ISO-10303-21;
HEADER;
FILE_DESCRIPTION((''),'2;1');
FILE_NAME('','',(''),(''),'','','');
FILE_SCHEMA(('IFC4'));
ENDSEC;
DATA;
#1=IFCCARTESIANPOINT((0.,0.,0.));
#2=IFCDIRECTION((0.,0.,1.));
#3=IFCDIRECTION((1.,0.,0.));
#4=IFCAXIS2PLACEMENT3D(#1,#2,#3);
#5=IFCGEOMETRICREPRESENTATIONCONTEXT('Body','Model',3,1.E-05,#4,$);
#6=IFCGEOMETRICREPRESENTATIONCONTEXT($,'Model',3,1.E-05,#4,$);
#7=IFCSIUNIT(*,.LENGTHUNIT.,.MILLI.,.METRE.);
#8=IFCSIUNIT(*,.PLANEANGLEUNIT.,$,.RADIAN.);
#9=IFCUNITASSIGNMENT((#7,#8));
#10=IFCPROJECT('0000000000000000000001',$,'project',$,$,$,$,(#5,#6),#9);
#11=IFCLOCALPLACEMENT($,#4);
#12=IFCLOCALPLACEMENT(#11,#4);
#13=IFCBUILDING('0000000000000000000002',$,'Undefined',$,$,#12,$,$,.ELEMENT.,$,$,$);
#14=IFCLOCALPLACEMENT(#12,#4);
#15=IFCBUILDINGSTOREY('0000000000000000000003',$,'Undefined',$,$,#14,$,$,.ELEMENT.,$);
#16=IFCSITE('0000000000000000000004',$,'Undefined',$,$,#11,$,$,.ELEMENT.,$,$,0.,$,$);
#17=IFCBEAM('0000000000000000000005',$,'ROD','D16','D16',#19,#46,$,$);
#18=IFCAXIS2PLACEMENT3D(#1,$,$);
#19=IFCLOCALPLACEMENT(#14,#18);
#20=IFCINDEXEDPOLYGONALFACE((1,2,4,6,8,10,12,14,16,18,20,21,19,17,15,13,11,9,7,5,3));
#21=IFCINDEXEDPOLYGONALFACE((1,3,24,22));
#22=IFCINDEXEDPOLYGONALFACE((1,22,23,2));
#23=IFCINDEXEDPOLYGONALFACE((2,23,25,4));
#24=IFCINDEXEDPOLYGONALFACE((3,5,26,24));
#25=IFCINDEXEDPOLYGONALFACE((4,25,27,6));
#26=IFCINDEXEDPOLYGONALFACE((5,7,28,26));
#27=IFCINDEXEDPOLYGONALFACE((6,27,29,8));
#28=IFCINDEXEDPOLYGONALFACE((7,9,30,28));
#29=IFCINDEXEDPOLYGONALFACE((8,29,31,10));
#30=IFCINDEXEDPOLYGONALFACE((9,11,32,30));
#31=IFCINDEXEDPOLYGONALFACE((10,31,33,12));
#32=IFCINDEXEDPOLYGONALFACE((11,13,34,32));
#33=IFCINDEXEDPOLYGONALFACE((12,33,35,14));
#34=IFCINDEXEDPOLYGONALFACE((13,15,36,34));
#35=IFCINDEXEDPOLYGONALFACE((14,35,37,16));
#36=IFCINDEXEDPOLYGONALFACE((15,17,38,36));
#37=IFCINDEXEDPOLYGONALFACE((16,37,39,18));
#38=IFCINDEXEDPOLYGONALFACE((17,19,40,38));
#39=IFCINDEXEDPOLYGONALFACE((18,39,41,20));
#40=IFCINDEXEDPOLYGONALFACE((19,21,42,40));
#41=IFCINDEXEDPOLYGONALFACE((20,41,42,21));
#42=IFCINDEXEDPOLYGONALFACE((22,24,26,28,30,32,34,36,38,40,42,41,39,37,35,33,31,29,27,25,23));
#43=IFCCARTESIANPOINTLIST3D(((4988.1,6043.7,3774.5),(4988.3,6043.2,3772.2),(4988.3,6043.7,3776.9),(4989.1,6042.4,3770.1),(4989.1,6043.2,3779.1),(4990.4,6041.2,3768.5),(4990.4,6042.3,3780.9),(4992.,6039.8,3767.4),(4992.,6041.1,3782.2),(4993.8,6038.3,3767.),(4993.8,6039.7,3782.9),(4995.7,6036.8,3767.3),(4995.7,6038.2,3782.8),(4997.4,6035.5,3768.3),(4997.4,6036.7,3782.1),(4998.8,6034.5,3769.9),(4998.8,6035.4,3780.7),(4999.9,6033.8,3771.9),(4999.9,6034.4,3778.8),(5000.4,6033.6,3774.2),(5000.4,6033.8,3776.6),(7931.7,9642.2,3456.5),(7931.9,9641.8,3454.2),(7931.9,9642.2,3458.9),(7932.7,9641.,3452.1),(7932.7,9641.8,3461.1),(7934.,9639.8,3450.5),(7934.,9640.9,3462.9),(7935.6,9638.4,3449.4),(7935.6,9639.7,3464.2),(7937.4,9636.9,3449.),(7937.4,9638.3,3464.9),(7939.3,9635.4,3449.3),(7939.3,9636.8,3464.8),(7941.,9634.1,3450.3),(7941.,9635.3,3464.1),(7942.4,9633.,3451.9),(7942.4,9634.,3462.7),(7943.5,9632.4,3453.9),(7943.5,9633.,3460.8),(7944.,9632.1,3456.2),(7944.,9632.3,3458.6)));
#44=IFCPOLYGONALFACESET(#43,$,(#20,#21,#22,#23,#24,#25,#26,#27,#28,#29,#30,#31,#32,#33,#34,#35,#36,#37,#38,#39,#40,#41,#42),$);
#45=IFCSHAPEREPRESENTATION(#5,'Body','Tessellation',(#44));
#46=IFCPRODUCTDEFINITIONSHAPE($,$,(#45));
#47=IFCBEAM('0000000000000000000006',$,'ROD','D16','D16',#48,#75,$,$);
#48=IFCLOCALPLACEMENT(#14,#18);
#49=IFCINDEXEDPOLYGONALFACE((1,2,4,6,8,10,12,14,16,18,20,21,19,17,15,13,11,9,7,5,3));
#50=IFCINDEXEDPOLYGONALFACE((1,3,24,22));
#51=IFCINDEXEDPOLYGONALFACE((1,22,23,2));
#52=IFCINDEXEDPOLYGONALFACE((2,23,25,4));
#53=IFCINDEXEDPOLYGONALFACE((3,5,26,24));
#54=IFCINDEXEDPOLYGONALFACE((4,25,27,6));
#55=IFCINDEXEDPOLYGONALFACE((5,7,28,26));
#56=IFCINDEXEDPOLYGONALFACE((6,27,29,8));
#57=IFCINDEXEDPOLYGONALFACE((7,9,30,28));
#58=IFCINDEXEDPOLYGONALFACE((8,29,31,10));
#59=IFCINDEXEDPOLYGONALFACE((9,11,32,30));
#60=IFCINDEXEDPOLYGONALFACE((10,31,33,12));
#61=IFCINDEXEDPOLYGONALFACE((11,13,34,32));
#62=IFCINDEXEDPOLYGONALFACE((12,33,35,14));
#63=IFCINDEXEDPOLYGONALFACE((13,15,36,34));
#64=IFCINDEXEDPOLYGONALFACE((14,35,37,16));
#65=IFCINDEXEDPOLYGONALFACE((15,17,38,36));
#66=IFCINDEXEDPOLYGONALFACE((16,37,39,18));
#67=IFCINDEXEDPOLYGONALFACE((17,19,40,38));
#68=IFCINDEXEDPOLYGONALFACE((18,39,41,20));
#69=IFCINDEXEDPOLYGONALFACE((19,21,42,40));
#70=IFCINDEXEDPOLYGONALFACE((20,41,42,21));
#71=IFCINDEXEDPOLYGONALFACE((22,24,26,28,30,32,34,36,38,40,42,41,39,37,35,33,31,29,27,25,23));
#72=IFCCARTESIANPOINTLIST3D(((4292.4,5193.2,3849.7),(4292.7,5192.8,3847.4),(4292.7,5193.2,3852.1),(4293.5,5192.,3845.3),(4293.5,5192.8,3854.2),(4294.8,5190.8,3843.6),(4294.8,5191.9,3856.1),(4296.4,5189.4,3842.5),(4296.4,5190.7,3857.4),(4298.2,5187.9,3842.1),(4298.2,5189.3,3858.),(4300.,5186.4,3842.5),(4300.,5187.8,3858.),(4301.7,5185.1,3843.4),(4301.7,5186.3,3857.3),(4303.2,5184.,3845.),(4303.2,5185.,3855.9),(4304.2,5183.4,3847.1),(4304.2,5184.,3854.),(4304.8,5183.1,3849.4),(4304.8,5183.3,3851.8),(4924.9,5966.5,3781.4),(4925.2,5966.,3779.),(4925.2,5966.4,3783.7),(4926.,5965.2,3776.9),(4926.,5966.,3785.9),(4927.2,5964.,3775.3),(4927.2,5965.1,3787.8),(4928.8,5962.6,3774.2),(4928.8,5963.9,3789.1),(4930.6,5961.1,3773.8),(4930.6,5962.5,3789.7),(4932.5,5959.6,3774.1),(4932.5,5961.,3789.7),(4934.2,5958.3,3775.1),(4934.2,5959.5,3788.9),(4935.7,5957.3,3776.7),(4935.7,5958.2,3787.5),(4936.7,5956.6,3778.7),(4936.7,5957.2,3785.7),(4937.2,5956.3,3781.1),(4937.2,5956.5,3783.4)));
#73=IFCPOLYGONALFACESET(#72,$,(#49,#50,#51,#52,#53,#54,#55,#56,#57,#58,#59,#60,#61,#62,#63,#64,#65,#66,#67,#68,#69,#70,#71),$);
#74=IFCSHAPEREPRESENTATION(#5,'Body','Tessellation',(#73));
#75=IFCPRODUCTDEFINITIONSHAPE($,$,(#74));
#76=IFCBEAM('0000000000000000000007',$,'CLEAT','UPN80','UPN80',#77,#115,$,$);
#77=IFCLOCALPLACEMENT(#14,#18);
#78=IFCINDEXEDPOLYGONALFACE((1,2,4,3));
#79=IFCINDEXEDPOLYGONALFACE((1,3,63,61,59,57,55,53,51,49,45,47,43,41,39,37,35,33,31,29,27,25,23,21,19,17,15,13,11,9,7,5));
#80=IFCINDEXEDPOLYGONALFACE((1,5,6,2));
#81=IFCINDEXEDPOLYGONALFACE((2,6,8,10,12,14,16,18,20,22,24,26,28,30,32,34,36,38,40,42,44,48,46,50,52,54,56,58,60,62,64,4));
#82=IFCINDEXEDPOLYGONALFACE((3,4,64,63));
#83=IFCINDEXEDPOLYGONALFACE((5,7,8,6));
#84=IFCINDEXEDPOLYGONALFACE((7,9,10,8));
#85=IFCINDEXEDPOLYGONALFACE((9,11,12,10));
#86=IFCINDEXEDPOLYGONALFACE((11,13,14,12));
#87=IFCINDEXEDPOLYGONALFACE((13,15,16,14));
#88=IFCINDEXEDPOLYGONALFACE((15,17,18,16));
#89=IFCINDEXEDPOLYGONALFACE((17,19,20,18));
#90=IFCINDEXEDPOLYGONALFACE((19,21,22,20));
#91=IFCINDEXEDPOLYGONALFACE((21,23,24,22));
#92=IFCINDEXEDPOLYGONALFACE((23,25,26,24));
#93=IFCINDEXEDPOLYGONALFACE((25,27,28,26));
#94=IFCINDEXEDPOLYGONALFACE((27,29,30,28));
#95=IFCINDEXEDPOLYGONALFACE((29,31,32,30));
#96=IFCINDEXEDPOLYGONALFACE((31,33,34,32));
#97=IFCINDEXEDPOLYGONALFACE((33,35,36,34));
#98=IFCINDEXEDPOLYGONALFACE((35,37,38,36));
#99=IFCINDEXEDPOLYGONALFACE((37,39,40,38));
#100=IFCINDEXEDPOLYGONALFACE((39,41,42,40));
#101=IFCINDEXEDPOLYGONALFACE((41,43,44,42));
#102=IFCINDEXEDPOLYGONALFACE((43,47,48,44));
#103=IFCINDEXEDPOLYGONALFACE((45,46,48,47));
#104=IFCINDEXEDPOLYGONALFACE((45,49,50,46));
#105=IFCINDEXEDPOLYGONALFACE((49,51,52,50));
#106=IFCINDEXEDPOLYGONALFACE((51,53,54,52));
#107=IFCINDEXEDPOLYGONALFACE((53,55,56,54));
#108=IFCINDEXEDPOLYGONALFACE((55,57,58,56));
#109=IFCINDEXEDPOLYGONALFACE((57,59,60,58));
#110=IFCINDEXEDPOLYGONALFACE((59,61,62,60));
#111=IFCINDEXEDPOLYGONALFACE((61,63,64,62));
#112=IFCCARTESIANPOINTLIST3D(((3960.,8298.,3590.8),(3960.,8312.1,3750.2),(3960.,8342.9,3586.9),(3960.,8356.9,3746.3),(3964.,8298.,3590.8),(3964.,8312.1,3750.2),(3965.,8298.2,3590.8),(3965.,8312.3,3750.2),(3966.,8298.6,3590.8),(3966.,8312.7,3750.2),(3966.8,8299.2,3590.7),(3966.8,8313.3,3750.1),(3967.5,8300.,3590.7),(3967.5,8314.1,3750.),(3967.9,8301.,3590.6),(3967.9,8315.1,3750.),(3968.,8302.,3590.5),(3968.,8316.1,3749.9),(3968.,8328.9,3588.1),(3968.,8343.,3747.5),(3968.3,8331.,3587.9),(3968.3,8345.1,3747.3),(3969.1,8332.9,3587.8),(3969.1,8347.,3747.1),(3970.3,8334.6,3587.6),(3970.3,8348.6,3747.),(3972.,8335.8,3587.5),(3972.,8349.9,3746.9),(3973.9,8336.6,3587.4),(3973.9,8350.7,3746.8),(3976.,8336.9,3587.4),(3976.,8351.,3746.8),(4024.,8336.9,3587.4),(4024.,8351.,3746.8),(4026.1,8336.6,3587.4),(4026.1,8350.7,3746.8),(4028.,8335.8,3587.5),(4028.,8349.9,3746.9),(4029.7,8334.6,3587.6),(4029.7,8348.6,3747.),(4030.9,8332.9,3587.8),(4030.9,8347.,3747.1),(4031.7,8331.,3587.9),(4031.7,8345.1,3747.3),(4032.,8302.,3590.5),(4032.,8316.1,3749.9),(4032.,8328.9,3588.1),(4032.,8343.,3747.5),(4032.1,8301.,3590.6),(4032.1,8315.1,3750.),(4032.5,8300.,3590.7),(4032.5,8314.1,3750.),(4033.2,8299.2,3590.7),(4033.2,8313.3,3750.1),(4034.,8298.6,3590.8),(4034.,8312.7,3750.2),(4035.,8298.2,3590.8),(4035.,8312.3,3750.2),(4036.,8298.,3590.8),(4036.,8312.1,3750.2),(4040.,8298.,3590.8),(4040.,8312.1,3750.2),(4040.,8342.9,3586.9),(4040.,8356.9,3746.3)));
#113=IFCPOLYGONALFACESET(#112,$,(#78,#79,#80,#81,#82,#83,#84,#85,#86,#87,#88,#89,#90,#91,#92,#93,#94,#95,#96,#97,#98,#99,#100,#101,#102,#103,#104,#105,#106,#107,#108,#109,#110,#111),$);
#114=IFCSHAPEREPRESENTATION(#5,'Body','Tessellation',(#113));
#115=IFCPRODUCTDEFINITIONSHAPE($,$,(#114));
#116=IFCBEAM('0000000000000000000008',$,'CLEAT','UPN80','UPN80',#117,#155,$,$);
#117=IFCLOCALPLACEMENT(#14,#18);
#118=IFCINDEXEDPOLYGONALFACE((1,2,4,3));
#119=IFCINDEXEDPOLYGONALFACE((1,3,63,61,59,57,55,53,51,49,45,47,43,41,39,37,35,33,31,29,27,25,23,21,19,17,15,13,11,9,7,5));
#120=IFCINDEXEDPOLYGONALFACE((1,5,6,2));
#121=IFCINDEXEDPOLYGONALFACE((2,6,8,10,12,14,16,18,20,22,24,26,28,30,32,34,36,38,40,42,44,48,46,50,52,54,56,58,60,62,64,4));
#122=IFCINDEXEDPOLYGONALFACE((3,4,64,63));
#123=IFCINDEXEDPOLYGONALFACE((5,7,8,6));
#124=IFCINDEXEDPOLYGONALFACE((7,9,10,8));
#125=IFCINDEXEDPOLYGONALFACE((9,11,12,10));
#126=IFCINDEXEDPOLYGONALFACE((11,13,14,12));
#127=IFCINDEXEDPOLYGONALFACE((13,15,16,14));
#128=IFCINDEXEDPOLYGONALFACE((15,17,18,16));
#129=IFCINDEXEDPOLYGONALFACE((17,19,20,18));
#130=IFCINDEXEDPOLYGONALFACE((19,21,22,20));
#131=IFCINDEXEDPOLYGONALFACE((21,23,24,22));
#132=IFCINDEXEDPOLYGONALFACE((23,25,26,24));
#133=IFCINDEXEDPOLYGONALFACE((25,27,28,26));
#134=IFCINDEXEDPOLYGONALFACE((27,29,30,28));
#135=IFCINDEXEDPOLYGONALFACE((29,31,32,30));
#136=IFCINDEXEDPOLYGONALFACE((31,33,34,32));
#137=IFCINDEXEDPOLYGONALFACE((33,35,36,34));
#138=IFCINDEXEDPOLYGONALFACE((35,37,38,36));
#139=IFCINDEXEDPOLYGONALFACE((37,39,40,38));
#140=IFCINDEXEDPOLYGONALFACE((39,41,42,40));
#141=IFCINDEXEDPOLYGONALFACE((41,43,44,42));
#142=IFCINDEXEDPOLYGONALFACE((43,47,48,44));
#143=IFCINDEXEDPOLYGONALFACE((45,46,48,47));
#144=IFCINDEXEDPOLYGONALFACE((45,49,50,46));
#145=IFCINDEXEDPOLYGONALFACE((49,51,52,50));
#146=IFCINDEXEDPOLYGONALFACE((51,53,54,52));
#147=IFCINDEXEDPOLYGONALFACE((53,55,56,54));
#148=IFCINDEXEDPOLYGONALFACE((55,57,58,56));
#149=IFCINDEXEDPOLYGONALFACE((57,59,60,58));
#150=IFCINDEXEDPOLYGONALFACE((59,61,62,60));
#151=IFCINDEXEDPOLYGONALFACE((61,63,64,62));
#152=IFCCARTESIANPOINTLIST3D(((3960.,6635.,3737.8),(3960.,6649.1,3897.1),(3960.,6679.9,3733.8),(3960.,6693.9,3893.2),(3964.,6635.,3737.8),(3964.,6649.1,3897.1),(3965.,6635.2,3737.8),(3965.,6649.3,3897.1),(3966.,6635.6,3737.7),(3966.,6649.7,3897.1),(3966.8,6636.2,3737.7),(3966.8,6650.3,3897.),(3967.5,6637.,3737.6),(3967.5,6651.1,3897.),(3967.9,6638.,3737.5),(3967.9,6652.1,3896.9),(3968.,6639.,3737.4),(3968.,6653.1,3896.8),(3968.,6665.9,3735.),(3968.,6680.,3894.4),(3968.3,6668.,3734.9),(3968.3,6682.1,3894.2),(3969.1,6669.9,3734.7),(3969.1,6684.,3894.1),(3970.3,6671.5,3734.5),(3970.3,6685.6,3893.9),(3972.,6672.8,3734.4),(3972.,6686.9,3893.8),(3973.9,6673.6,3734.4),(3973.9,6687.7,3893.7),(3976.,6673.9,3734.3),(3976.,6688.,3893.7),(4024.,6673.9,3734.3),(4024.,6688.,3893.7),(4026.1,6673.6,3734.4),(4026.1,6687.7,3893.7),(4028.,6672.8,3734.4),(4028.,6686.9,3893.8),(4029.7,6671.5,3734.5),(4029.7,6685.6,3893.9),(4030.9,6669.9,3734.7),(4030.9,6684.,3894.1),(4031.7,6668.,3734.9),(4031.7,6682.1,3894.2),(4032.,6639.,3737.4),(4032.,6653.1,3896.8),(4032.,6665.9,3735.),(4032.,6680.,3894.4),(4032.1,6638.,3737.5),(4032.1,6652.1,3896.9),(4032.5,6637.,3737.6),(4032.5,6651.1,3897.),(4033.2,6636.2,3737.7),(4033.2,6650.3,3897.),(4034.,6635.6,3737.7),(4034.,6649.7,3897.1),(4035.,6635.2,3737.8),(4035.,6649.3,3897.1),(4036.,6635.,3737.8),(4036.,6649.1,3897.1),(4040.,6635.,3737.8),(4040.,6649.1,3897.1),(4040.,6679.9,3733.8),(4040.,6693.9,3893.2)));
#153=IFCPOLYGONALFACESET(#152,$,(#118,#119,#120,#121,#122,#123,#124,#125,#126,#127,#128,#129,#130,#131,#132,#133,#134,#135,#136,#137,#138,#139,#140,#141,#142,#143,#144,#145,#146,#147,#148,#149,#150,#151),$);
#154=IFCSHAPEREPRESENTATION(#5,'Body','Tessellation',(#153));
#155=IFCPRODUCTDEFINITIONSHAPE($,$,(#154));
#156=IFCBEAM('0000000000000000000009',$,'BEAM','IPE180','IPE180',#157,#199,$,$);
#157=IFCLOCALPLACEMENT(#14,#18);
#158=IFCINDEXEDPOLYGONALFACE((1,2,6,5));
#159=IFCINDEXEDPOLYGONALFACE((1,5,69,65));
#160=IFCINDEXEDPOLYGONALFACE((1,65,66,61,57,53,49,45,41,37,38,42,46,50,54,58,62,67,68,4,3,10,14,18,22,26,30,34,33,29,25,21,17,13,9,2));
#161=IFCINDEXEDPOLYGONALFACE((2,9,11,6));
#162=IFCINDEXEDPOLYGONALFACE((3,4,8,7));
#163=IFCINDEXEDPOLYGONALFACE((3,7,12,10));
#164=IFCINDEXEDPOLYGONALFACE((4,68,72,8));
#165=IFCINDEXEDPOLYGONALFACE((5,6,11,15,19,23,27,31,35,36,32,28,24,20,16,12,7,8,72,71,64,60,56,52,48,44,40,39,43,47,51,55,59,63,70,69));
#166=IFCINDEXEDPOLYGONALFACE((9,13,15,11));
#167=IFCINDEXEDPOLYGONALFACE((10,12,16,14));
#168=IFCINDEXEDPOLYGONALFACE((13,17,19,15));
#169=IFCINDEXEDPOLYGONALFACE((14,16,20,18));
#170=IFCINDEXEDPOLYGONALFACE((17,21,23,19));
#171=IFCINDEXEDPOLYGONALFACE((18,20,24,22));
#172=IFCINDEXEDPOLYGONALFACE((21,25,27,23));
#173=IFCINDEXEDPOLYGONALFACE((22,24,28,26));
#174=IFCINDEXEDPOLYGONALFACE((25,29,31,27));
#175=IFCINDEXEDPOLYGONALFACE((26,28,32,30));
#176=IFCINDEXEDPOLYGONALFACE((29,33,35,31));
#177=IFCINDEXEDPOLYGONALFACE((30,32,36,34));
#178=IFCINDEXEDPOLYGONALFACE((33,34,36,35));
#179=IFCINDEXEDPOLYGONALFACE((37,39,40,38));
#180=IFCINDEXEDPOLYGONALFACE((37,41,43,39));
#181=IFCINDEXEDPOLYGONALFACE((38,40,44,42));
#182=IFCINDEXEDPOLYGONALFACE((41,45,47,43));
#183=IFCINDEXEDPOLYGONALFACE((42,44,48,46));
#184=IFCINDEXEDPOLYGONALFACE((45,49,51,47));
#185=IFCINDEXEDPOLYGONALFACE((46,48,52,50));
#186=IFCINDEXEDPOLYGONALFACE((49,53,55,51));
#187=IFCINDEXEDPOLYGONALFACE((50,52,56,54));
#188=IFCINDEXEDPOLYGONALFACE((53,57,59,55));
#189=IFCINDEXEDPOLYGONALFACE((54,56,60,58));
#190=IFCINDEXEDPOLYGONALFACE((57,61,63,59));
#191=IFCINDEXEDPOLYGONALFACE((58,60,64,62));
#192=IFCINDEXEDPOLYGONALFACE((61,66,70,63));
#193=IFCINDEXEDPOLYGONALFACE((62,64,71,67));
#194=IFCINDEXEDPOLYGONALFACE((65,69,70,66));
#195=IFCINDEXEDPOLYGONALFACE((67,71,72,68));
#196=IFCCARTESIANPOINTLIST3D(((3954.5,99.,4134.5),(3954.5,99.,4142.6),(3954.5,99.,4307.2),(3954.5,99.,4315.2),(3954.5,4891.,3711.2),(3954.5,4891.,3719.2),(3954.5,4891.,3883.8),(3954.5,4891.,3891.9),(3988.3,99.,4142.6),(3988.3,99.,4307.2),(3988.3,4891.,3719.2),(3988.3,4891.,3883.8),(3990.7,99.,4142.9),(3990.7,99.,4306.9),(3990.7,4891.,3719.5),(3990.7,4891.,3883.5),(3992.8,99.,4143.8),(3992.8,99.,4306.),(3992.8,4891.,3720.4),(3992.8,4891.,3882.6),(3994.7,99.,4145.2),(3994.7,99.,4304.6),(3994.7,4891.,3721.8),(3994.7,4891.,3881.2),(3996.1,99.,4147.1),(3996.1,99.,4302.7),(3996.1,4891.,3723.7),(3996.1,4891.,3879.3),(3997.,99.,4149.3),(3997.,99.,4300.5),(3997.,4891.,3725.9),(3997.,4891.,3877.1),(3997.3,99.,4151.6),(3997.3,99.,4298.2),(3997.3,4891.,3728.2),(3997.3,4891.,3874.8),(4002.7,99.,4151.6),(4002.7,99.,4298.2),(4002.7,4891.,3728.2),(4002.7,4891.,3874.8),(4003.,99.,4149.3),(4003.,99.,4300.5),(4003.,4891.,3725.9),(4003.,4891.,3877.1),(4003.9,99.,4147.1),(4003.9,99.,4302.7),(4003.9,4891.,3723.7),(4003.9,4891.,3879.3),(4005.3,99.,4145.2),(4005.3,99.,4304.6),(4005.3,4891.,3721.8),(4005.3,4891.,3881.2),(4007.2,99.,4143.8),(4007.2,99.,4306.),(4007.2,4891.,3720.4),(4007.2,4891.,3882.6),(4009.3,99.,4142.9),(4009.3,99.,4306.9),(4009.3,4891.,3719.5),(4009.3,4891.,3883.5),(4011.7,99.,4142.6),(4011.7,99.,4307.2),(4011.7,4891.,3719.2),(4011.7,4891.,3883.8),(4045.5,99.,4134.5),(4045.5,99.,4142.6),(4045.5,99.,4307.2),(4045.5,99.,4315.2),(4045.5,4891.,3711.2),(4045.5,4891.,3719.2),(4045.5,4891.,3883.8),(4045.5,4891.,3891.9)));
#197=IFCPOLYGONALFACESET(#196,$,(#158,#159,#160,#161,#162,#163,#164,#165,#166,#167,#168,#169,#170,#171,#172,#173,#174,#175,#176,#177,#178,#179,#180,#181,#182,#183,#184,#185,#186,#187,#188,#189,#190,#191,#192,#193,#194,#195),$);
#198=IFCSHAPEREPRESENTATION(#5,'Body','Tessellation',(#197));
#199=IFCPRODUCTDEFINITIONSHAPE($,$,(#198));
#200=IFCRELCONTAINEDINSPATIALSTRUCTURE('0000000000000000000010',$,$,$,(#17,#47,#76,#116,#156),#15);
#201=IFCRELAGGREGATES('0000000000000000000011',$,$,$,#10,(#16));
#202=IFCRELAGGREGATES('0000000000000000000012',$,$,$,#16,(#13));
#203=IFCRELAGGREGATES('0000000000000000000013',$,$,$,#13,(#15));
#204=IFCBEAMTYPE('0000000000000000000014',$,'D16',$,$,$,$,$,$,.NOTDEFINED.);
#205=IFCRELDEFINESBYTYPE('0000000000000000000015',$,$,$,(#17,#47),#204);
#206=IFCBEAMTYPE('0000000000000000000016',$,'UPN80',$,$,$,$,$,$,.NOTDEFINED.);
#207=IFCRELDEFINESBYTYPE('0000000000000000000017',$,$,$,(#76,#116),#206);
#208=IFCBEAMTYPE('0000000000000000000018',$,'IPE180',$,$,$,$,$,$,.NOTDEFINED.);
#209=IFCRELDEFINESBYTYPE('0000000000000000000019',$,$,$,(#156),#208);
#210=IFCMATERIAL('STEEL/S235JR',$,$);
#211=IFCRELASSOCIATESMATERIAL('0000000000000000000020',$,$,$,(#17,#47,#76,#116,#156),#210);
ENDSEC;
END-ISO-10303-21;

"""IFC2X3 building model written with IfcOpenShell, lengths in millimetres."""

from ifc_helpers import new_model, si_unit, frame, origin_with_axes, origin_2d_with_axis, place, context, project, spatial, circle, i_section, u_section, extrude, clip, halfspace, material, type_object, element, save


model = new_model("IFC2X3")

# Units and contexts
model_context_1 = context("Model", 3, precision=1e-05, world=origin_with_axes(), identifier="Body")
model_context_2 = context("Model", 3, precision=1e-05, world=origin_with_axes())
ifc_project = project(units=[si_unit("LENGTHUNIT", "METRE", prefix="MILLI"), si_unit("PLANEANGLEUNIT", "RADIAN")], contexts=[model_context_1, model_context_2])

# Site, building, storey
site_placement = place(None, origin_with_axes())
site = spatial("IfcSite", under=ifc_project, at=site_placement, Name="Undefined", CompositionType="ELEMENT", RefElevation=0.0)
building_placement = place(site_placement, origin_with_axes())
building = spatial("IfcBuilding", under=site, at=building_placement, Name="Undefined", CompositionType="ELEMENT")
storey_placement = place(building_placement, origin_with_axes())
storey = spatial("IfcBuildingStorey", under=building, at=storey_placement, Name="Undefined", CompositionType="ELEMENT")

# Shared definitions
ifc_material = material(Name="STEEL/S235JR")

# Beams
beam_type_1 = type_object("IfcBeamType", Name="D16", PredefinedType="NOTDEFINED")
beam_1_placement = place(storey_placement, frame((4994.3, 6038.6, 3775.0), z_axis=(0.0, -0.088027, -0.996118), x_axis=(0.631673, 0.772225, -0.068242)))
element("IfcBeam", 1, at=beam_1_placement, inside=storey, type_object=beam_type_1, material=ifc_material, Name="ROD", Description="D16", ObjectType="D16", context=model_context_1, shape_type="SweptSolid", body=[
    extrude(circle(Radius=8.0, at=origin_2d_with_axis()), frame((4660.0, 0.0, 0.0), z_axis=(-1.0, 0.0, 0.0), x_axis=(0.0, -1.0, 0.0)), (0.0, 0.0, 1.0), 4660.0),
])
beam_2_placement = place(storey_placement, frame((4298.6, 5188.2, 3850.1), z_axis=(0.0, -0.088027, -0.996118), x_axis=(0.631673, 0.772225, -0.068242)))
element("IfcBeam", 2, at=beam_2_placement, inside=storey, type_object=beam_type_1, material=ifc_material, Name="ROD", Description="D16", ObjectType="D16", context=model_context_1, shape_type="SweptSolid", body=[
    extrude(circle(Radius=8.0, at=origin_2d_with_axis()), frame((1001.3, 0.0, 0.0), z_axis=(-1.0, 0.0, 0.0), x_axis=(0.0, -1.0, 0.0)), (0.0, 0.0, 1.0), 1001.3),
])
beam_type_2 = type_object("IfcBeamType", Name="UPN80", PredefinedType="NOTDEFINED")
for number, where, z_axis, x_axis, name in (
    (3, (4000.0, 8320.4, 3588.9), (-1.0, 0.0, 0.0), (0.0, 0.08801, 0.99612), "CLEAT"),
    (4, (4000.0, 6657.4, 3735.8), (-1.0, 0.0, 0.0), (0.0, 0.08801, 0.99612), "CLEAT"),
):
    element("IfcBeam", number, at=place(storey_placement, frame(where, z_axis=z_axis, x_axis=x_axis)), inside=storey, type_object=beam_type_2, material=ifc_material, Name=name, Description="UPN80", ObjectType="UPN80", context=model_context_1, shape_type="SweptSolid", body=[
        extrude(u_section(Depth=80.0, FlangeWidth=45.0, WebThickness=6.0, FlangeThickness=8.0, FilletRadius=8.0, EdgeRadius=4.0, at=origin_2d_with_axis()), frame((160.0, 0.0, 0.0), z_axis=(-1.0, 0.0, 0.0), x_axis=(0.0, -1.0, 0.0)), (0.0, 0.0, 1.0), 160.0),
    ])
beam_type_3 = type_object("IfcBeamType", Name="IPE180", PredefinedType="NOTDEFINED")
beam_3_placement = place(storey_placement, frame((4000.0, 4910.6, 3799.8), z_axis=(0.0, 0.08801, 0.99612), x_axis=(0.0, -0.99612, 0.08801)))
element("IfcBeam", 5, at=beam_3_placement, inside=storey, type_object=beam_type_3, material=ifc_material, Name="BEAM", Description="IPE180", ObjectType="IPE180", context=model_context_1, shape_type="Clipping", body=[
    clip(clip(extrude(i_section(OverallWidth=91.0, OverallDepth=180.0, WebThickness=5.3, FlangeThickness=8.0, FilletRadius=9.0, at=origin_2d_with_axis()), frame((4846.4, 0.0, 0.0), z_axis=(-1.0, 0.0, 0.0), x_axis=(0.0, -1.0, 0.0)), (0.0, 0.0, 1.0), 4842.8), halfspace(frame((11.7, 0.0, -90.0), z_axis=(0.99612, 0.0, -0.08801), x_axis=(0.0, -1.0, 0.0)), True)), halfspace(frame((4839.2, 0.0, 100.8), z_axis=(0.99612, 0.0, -0.08801), x_axis=(0.0, 1.0, 0.0)), False)),
])

save(model, "model.ifc")
